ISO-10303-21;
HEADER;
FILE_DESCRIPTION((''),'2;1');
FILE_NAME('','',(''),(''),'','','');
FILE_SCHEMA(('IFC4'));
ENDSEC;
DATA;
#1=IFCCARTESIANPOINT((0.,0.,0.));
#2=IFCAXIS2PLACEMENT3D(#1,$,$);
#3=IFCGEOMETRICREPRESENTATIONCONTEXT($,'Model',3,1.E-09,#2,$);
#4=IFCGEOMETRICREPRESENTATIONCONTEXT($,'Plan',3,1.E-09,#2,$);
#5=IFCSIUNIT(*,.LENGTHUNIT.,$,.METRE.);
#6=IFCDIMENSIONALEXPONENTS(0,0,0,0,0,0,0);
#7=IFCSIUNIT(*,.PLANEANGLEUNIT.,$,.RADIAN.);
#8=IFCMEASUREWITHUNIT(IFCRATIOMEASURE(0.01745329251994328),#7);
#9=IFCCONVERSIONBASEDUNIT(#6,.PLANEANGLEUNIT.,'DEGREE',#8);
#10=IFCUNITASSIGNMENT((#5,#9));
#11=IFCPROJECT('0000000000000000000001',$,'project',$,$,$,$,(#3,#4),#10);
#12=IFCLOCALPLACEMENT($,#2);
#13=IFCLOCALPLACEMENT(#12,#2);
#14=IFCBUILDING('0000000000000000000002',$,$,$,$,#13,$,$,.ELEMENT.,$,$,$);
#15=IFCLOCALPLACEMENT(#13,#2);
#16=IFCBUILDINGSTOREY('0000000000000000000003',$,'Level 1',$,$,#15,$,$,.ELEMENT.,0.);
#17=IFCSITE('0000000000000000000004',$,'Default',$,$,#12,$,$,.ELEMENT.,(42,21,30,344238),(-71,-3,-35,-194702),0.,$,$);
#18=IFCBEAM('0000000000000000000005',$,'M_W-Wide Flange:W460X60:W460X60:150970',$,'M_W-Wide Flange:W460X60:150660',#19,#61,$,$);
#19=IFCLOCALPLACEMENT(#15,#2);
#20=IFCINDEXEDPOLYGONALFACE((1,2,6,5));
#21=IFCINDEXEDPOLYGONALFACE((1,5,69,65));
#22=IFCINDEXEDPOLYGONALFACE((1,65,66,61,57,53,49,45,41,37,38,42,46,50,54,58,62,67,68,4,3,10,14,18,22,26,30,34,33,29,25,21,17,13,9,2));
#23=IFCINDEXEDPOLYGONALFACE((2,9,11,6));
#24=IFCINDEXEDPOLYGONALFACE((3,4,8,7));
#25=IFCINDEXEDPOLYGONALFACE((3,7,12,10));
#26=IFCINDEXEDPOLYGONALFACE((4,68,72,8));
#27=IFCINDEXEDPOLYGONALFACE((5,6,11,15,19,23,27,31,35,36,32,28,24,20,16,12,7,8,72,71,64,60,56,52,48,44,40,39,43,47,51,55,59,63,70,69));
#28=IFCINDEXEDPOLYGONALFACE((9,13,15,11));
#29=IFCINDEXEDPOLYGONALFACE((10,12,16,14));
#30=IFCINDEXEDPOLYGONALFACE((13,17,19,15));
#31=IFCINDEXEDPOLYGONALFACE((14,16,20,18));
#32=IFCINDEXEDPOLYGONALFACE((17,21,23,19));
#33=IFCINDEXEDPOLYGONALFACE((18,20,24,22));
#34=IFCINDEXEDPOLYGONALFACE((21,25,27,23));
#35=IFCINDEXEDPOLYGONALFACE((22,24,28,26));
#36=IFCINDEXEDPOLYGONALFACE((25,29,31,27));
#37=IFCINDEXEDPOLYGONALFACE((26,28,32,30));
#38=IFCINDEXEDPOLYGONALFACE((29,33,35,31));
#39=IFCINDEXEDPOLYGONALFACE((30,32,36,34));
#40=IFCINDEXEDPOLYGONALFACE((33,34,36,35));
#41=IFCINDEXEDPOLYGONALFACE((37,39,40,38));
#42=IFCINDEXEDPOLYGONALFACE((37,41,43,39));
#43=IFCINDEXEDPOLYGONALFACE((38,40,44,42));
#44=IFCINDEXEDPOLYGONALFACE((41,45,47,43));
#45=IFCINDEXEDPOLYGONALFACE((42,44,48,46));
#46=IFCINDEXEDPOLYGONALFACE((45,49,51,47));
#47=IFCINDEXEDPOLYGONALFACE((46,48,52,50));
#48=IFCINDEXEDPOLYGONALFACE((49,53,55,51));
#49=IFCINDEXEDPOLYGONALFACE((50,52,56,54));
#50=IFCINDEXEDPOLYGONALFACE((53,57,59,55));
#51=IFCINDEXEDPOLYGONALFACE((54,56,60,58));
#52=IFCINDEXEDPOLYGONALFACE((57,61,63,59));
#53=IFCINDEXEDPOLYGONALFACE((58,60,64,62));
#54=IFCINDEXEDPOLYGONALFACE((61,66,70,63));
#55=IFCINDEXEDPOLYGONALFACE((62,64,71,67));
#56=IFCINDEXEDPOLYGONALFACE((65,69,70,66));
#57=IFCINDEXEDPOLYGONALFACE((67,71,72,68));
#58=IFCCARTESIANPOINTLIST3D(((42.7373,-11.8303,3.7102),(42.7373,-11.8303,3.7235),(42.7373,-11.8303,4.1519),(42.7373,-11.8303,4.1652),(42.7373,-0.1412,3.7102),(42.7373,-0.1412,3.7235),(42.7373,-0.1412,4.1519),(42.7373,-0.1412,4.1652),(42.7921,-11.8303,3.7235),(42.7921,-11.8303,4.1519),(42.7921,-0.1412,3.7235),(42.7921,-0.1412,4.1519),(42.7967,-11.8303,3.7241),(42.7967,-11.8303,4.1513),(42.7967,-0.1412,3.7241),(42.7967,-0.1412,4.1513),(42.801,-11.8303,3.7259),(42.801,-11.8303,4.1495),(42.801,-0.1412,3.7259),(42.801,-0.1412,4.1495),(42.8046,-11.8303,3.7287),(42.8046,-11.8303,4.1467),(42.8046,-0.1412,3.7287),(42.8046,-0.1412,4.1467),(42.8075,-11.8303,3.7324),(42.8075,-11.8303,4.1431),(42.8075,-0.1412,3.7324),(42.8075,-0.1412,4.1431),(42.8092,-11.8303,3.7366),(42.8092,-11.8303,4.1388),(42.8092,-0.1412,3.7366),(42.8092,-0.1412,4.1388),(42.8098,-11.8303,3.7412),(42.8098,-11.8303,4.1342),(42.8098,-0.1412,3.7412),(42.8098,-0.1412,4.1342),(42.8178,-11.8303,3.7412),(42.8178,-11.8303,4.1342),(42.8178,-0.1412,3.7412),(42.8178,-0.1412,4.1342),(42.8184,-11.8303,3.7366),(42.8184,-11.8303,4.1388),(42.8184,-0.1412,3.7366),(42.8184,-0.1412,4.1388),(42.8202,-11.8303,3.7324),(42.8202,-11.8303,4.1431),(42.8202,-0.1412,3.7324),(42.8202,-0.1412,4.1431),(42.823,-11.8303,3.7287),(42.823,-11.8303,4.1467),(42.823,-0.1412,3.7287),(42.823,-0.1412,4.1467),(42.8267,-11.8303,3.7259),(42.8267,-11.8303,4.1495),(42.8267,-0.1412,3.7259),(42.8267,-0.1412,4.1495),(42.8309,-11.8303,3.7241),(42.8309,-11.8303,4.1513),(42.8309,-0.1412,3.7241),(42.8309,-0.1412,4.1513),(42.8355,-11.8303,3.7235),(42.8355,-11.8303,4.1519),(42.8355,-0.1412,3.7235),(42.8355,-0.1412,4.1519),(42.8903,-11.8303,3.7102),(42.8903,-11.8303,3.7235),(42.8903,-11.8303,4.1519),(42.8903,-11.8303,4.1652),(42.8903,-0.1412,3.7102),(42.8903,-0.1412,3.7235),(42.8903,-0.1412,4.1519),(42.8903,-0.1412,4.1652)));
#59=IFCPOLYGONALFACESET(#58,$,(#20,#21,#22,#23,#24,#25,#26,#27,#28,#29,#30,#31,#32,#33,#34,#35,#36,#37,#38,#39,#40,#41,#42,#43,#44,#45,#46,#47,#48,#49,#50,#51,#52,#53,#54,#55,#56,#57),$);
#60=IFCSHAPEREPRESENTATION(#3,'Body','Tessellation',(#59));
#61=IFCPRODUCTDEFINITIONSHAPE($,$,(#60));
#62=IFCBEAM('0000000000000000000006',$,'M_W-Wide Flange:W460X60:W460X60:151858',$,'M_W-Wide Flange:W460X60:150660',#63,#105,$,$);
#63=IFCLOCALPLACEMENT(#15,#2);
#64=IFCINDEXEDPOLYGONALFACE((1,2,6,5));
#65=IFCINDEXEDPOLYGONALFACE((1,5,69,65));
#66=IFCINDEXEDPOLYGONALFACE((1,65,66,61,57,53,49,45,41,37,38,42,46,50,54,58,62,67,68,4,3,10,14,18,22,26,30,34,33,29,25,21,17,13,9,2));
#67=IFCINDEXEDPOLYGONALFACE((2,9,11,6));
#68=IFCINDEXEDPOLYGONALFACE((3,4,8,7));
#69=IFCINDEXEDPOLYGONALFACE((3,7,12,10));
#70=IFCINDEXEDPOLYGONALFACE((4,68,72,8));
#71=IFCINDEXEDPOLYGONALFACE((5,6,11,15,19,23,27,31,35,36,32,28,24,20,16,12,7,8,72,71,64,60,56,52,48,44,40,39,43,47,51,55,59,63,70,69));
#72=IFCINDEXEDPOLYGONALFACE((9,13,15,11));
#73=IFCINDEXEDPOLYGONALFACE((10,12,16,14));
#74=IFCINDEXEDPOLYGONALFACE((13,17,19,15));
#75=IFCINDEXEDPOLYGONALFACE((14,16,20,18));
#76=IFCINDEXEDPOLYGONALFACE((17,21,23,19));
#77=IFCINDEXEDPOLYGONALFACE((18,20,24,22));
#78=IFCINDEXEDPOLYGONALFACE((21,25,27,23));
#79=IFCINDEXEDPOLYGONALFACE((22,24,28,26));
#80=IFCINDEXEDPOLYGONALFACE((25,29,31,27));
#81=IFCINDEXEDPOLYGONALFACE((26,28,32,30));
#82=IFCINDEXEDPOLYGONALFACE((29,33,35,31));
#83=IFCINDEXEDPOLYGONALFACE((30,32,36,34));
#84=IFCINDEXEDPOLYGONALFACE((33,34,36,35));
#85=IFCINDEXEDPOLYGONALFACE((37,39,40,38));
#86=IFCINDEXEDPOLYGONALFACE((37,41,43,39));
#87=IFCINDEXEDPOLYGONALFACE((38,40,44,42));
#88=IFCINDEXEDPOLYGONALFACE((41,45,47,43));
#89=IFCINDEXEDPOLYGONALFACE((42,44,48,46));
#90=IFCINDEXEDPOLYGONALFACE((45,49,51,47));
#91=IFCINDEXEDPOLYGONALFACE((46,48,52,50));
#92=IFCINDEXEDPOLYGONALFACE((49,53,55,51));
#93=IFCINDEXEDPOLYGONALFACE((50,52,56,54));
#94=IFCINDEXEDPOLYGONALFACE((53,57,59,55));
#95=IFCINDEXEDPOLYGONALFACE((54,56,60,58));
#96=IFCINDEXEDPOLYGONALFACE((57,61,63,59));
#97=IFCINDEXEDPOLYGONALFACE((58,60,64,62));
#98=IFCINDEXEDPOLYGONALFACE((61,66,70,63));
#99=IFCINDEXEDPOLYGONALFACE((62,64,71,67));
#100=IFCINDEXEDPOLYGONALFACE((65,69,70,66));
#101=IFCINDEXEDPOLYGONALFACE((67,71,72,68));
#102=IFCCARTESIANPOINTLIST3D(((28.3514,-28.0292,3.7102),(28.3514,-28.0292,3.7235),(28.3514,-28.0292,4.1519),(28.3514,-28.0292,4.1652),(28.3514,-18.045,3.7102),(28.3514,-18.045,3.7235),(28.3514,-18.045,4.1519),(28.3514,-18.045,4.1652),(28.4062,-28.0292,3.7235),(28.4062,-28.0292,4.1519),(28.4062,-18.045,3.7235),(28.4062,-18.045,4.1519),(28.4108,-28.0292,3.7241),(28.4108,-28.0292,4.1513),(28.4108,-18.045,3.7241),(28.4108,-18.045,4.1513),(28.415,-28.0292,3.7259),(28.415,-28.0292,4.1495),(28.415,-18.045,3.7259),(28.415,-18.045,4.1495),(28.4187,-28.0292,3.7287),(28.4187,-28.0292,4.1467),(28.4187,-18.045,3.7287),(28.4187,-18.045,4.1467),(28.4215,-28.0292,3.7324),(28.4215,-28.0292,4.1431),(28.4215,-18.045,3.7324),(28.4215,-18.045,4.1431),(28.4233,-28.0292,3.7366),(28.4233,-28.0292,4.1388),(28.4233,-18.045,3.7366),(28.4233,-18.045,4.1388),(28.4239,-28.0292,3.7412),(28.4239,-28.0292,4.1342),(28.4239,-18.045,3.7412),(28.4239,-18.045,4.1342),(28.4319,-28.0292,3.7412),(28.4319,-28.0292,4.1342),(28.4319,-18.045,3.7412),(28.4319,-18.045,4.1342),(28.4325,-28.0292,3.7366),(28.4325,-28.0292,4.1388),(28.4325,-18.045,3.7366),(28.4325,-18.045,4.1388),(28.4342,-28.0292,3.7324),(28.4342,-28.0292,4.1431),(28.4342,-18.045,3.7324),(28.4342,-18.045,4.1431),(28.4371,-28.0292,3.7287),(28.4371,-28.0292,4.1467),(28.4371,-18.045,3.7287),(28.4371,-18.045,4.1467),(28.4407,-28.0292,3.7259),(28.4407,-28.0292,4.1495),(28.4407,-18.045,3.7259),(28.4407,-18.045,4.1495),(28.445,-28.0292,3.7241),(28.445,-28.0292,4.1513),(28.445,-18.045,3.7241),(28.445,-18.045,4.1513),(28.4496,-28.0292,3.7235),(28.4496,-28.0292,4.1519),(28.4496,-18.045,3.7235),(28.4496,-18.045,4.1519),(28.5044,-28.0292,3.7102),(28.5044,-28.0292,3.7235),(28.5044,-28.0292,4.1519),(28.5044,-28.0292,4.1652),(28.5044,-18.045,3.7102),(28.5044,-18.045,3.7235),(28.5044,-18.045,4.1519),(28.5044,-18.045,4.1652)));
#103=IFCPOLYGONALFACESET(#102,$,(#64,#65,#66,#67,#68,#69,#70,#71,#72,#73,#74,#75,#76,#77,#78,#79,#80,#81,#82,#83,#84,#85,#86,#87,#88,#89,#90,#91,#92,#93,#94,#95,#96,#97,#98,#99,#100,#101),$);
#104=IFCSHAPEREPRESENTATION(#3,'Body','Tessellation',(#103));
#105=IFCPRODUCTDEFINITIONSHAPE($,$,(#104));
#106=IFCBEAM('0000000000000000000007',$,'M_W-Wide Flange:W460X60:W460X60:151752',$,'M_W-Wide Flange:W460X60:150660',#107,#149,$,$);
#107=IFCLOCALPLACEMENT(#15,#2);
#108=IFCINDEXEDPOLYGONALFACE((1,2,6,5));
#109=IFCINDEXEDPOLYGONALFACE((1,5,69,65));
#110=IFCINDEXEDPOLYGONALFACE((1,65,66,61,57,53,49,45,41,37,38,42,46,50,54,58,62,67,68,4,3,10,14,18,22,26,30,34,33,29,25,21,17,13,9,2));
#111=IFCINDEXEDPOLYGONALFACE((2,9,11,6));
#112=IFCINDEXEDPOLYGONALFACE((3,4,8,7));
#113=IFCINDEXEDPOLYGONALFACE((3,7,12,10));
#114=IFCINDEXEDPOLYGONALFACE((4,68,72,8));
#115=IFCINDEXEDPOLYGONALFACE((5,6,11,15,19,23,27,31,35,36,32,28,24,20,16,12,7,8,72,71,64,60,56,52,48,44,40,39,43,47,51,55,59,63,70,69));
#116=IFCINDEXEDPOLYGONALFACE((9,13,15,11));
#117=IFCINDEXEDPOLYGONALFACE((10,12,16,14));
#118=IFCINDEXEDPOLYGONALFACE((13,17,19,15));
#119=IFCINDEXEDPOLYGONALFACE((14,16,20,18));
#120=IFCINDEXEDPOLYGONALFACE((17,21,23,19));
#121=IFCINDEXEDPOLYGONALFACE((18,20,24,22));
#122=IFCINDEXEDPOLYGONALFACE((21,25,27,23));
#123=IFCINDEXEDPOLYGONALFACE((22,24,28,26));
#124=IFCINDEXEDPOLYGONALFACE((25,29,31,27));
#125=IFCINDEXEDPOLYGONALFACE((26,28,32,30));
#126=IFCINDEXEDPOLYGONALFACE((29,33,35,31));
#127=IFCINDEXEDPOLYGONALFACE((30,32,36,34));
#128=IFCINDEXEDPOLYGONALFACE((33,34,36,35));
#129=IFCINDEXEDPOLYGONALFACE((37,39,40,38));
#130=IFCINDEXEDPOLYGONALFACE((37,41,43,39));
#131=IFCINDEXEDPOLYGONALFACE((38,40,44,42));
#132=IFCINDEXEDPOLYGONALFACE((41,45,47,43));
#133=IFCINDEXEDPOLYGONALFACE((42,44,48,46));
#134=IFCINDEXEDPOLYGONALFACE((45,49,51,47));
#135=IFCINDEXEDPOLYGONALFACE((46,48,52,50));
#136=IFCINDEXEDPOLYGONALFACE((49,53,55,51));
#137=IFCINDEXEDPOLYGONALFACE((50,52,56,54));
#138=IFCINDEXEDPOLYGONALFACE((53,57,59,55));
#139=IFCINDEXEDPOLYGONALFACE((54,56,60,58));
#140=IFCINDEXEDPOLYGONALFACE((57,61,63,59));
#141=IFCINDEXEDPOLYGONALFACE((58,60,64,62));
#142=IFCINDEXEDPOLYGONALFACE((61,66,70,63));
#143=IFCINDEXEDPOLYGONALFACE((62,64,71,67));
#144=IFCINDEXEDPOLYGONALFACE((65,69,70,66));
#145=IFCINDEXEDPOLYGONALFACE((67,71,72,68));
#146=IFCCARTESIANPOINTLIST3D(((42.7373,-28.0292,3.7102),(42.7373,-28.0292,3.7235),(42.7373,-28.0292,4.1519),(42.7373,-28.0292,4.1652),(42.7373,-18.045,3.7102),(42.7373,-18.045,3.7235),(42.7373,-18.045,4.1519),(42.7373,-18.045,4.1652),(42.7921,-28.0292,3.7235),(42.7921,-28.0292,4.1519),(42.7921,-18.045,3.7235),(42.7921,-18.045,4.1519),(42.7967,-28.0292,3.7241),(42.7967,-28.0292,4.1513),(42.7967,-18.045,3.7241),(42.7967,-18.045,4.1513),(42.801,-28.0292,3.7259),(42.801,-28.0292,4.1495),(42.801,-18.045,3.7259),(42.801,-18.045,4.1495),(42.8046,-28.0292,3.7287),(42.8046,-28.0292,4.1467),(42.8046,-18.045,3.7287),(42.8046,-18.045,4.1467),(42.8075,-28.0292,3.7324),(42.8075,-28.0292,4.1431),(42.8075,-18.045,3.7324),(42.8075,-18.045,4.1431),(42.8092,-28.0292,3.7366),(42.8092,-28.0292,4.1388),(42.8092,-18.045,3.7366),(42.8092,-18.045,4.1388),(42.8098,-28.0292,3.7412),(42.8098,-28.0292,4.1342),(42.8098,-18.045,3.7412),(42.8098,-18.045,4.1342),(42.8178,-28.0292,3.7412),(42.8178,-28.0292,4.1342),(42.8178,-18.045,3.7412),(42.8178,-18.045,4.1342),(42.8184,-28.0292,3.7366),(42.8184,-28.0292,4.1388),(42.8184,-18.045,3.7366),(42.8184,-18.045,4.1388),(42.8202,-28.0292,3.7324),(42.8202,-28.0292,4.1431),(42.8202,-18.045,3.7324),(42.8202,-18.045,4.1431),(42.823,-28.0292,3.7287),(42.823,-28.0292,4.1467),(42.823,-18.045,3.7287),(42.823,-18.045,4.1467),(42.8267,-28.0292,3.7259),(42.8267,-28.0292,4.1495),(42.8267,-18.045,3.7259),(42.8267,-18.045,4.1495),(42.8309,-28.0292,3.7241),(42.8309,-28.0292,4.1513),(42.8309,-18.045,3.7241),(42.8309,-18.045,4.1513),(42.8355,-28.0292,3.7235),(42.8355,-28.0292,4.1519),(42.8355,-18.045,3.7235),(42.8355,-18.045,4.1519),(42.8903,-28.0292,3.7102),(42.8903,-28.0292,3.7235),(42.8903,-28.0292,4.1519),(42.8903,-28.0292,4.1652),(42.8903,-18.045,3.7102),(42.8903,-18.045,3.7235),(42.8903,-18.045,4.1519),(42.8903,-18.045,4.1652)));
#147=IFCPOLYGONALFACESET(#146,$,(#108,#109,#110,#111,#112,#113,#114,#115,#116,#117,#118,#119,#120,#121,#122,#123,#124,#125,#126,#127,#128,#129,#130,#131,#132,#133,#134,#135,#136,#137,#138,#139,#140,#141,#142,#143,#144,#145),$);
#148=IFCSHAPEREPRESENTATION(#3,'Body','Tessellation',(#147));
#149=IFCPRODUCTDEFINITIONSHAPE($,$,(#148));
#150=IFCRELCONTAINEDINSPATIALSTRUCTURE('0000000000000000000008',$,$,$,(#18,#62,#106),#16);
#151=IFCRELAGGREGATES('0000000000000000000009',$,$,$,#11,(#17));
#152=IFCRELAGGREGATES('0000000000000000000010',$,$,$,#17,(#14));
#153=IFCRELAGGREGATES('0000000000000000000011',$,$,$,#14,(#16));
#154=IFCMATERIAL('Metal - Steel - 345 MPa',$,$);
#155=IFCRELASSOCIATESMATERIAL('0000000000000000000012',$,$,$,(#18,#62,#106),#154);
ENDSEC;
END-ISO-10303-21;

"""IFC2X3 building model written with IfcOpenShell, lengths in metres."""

from ifc_helpers import new_model, entity, si_unit, converted_unit, frame, frame_2d, origin, place, context, project, spatial, polyline, circle_curve, parameter, trimmed, segment, composite_curve, outline, extrude, material, element, save


model = new_model("IFC2X3")

# Units and contexts
model_context = context("Model", 3, precision=1e-09, world=origin())
plan_context = context("Plan", 3, precision=1e-09, world=origin())
ifc_project = project(units=[si_unit("LENGTHUNIT", "METRE"), converted_unit("PLANEANGLEUNIT", "DEGREE", entity("IfcRatioMeasure", 0.01745329251994328), si_unit("PLANEANGLEUNIT", "RADIAN"), dimensions=[0, 0, 0, 0, 0, 0, 0])], contexts=[model_context, plan_context])

# Site, building, storey
site_placement = place(None, origin())
site = spatial("IfcSite", under=ifc_project, at=site_placement, Name="Default", CompositionType="ELEMENT", RefLatitude=(42, 21, 30, 344238), RefLongitude=(-71, -3, -35, -194702), RefElevation=0.0)
building_placement = place(site_placement, origin())
building = spatial("IfcBuilding", under=site, at=building_placement, CompositionType="ELEMENT")
storey_placement = place(building_placement, origin())
storey = spatial("IfcBuildingStorey", under=building, at=storey_placement, Name="Level 1", CompositionType="ELEMENT", Elevation=0.0)

# Beams
ifc_material = material(Name="Metal - Steel - 345 MPa")
beam_1_placement = place(storey_placement, frame((42.8138, 0.0, 4.2672), z_axis=(0.0, 0.0, 1.0), x_axis=(-1.0, 0.0, 0.0)))
element("IfcBeam", 1, at=beam_1_placement, inside=storey, material=ifc_material, Name="M_W-Wide Flange:W460X60:W460X60:150970", ObjectType="M_W-Wide Flange:W460X60:150660", context=model_context, shape_type="SweptSolid", body=[
    extrude(outline(composite_curve([segment(polyline([(0.2142, -0.0765), (0.2275, -0.0765)]), True, "CONTINUOUS"), segment(polyline([(0.2275, -0.0765), (0.2275, 0.0765)]), True, "CONTINUOUS"), segment(polyline([(0.2275, 0.0765), (0.2142, 0.0765)]), True, "CONTINUOUS"), segment(polyline([(0.2142, 0.0765), (0.2142, 0.0217)]), True, "CONTINUOUS"), segment(trimmed(circle_curve(frame_2d((0.1965, 0.0217), x_axis=(0.0, 1.0)), 0.0177), [parameter(180.0)], [parameter(270.0)], True, "PARAMETER"), False, "CONTINUOUS"), segment(polyline([(0.1965, 0.004), (-0.1965, 0.004)]), True, "CONTINUOUS"), segment(trimmed(circle_curve(frame_2d((-0.1965, 0.0217), x_axis=(0.0, 1.0)), 0.0177), [parameter(90.0)], [parameter(180.0)], True, "PARAMETER"), False, "CONTINUOUS"), segment(polyline([(-0.2142, 0.0217), (-0.2142, 0.0765)]), True, "CONTINUOUS"), segment(polyline([(-0.2142, 0.0765), (-0.2275, 0.0765)]), True, "CONTINUOUS"), segment(polyline([(-0.2275, 0.0765), (-0.2275, -0.0765)]), True, "CONTINUOUS"), segment(polyline([(-0.2275, -0.0765), (-0.2142, -0.0765)]), True, "CONTINUOUS"), segment(polyline([(-0.2142, -0.0765), (-0.2142, -0.0217)]), True, "CONTINUOUS"), segment(trimmed(circle_curve(frame_2d((-0.1965, -0.0217), x_axis=(0.0, 1.0)), 0.0177), [parameter(360.0)], [parameter(90.0)], True, "PARAMETER"), False, "CONTINUOUS"), segment(polyline([(-0.1965, -0.004), (0.1965, -0.004)]), True, "CONTINUOUS"), segment(trimmed(circle_curve(frame_2d((0.1965, -0.0217), x_axis=(0.0, 1.0)), 0.0177), [parameter(270.0)], [parameter(0.0)], True, "PARAMETER"), False, "CONTINUOUS"), segment(polyline([(0.2142, -0.0217), (0.2142, -0.0765)]), True, "CONTINUOUS")], self_intersect=False)), frame((0.0, 11.8303, -0.3295), z_axis=(0.0, -1.0, 0.0), x_axis=(0.0, 0.0, -1.0)), (0.0, 0.0, 1.0), 11.6891),
])
beam_2_placement = place(storey_placement, frame((28.4279, -17.9038, 4.2672), z_axis=(0.0, 0.0, 1.0), x_axis=(-1.0, 0.0, 0.0)))
element("IfcBeam", 2, at=beam_2_placement, inside=storey, material=ifc_material, Name="M_W-Wide Flange:W460X60:W460X60:151858", ObjectType="M_W-Wide Flange:W460X60:150660", context=model_context, shape_type="SweptSolid", body=[
    extrude(outline(composite_curve([segment(polyline([(0.2142, -0.0765), (0.2275, -0.0765)]), True, "CONTINUOUS"), segment(polyline([(0.2275, -0.0765), (0.2275, 0.0765)]), True, "CONTINUOUS"), segment(polyline([(0.2275, 0.0765), (0.2142, 0.0765)]), True, "CONTINUOUS"), segment(polyline([(0.2142, 0.0765), (0.2142, 0.0217)]), True, "CONTINUOUS"), segment(trimmed(circle_curve(frame_2d((0.1965, 0.0217), x_axis=(1.0, 0.0)), 0.0177), [parameter(270.0)], [parameter(360.0)], True, "PARAMETER"), False, "CONTINUOUS"), segment(polyline([(0.1965, 0.004), (-0.1965, 0.004)]), True, "CONTINUOUS"), segment(trimmed(circle_curve(frame_2d((-0.1965, 0.0217), x_axis=(0.0, -1.0)), 0.0177), [parameter(270.0)], [parameter(360.0)], True, "PARAMETER"), False, "CONTINUOUS"), segment(polyline([(-0.2142, 0.0217), (-0.2142, 0.0765)]), True, "CONTINUOUS"), segment(polyline([(-0.2142, 0.0765), (-0.2275, 0.0765)]), True, "CONTINUOUS"), segment(polyline([(-0.2275, 0.0765), (-0.2275, -0.0765)]), True, "CONTINUOUS"), segment(polyline([(-0.2275, -0.0765), (-0.2142, -0.0765)]), True, "CONTINUOUS"), segment(polyline([(-0.2142, -0.0765), (-0.2142, -0.0217)]), True, "CONTINUOUS"), segment(trimmed(circle_curve(frame_2d((-0.1965, -0.0217), x_axis=(-1.0, 0.0)), 0.0177), [parameter(270.0)], [parameter(360.0)], True, "PARAMETER"), False, "CONTINUOUS"), segment(polyline([(-0.1965, -0.004), (0.1965, -0.004)]), True, "CONTINUOUS"), segment(trimmed(circle_curve(frame_2d((0.1965, -0.0217), x_axis=(0.0, 1.0)), 0.0177), [parameter(270.0)], [parameter(0.0)], True, "PARAMETER"), False, "CONTINUOUS"), segment(polyline([(0.2142, -0.0217), (0.2142, -0.0765)]), True, "CONTINUOUS")], self_intersect=False)), frame((0.0, 10.1253, -0.3295), z_axis=(0.0, -1.0, 0.0), x_axis=(0.0, 0.0, -1.0)), (0.0, 0.0, 1.0), 9.9841),
])
beam_3_placement = place(storey_placement, frame((42.8138, -17.9038, 4.2672), z_axis=(0.0, 0.0, 1.0), x_axis=(-1.0, 0.0, 0.0)))
element("IfcBeam", 3, at=beam_3_placement, inside=storey, material=ifc_material, Name="M_W-Wide Flange:W460X60:W460X60:151752", ObjectType="M_W-Wide Flange:W460X60:150660", context=model_context, shape_type="SweptSolid", body=[
    extrude(outline(composite_curve([segment(polyline([(0.2142, -0.0765), (0.2275, -0.0765)]), True, "CONTINUOUS"), segment(polyline([(0.2275, -0.0765), (0.2275, 0.0765)]), True, "CONTINUOUS"), segment(polyline([(0.2275, 0.0765), (0.2142, 0.0765)]), True, "CONTINUOUS"), segment(polyline([(0.2142, 0.0765), (0.2142, 0.0217)]), True, "CONTINUOUS"), segment(trimmed(circle_curve(frame_2d((0.1965, 0.0217), x_axis=(1.0, 0.0)), 0.0177), [parameter(270.0)], [parameter(360.0)], True, "PARAMETER"), False, "CONTINUOUS"), segment(polyline([(0.1965, 0.004), (-0.1965, 0.004)]), True, "CONTINUOUS"), segment(trimmed(circle_curve(frame_2d((-0.1965, 0.0217), x_axis=(0.0, -1.0)), 0.0177), [parameter(270.0)], [parameter(360.0)], True, "PARAMETER"), False, "CONTINUOUS"), segment(polyline([(-0.2142, 0.0217), (-0.2142, 0.0765)]), True, "CONTINUOUS"), segment(polyline([(-0.2142, 0.0765), (-0.2275, 0.0765)]), True, "CONTINUOUS"), segment(polyline([(-0.2275, 0.0765), (-0.2275, -0.0765)]), True, "CONTINUOUS"), segment(polyline([(-0.2275, -0.0765), (-0.2142, -0.0765)]), True, "CONTINUOUS"), segment(polyline([(-0.2142, -0.0765), (-0.2142, -0.0217)]), True, "CONTINUOUS"), segment(trimmed(circle_curve(frame_2d((-0.1965, -0.0217), x_axis=(-1.0, 0.0)), 0.0177), [parameter(270.0)], [parameter(360.0)], True, "PARAMETER"), False, "CONTINUOUS"), segment(polyline([(-0.1965, -0.004), (0.1965, -0.004)]), True, "CONTINUOUS"), segment(trimmed(circle_curve(frame_2d((0.1965, -0.0217), x_axis=(0.0, 1.0)), 0.0177), [parameter(270.0)], [parameter(0.0)], True, "PARAMETER"), False, "CONTINUOUS"), segment(polyline([(0.2142, -0.0217), (0.2142, -0.0765)]), True, "CONTINUOUS")], self_intersect=False)), frame((0.0, 10.1253, -0.3295), z_axis=(0.0, -1.0, 0.0), x_axis=(0.0, 0.0, -1.0)), (0.0, 0.0, 1.0), 9.9841),
])

save(model, "model.ifc")
